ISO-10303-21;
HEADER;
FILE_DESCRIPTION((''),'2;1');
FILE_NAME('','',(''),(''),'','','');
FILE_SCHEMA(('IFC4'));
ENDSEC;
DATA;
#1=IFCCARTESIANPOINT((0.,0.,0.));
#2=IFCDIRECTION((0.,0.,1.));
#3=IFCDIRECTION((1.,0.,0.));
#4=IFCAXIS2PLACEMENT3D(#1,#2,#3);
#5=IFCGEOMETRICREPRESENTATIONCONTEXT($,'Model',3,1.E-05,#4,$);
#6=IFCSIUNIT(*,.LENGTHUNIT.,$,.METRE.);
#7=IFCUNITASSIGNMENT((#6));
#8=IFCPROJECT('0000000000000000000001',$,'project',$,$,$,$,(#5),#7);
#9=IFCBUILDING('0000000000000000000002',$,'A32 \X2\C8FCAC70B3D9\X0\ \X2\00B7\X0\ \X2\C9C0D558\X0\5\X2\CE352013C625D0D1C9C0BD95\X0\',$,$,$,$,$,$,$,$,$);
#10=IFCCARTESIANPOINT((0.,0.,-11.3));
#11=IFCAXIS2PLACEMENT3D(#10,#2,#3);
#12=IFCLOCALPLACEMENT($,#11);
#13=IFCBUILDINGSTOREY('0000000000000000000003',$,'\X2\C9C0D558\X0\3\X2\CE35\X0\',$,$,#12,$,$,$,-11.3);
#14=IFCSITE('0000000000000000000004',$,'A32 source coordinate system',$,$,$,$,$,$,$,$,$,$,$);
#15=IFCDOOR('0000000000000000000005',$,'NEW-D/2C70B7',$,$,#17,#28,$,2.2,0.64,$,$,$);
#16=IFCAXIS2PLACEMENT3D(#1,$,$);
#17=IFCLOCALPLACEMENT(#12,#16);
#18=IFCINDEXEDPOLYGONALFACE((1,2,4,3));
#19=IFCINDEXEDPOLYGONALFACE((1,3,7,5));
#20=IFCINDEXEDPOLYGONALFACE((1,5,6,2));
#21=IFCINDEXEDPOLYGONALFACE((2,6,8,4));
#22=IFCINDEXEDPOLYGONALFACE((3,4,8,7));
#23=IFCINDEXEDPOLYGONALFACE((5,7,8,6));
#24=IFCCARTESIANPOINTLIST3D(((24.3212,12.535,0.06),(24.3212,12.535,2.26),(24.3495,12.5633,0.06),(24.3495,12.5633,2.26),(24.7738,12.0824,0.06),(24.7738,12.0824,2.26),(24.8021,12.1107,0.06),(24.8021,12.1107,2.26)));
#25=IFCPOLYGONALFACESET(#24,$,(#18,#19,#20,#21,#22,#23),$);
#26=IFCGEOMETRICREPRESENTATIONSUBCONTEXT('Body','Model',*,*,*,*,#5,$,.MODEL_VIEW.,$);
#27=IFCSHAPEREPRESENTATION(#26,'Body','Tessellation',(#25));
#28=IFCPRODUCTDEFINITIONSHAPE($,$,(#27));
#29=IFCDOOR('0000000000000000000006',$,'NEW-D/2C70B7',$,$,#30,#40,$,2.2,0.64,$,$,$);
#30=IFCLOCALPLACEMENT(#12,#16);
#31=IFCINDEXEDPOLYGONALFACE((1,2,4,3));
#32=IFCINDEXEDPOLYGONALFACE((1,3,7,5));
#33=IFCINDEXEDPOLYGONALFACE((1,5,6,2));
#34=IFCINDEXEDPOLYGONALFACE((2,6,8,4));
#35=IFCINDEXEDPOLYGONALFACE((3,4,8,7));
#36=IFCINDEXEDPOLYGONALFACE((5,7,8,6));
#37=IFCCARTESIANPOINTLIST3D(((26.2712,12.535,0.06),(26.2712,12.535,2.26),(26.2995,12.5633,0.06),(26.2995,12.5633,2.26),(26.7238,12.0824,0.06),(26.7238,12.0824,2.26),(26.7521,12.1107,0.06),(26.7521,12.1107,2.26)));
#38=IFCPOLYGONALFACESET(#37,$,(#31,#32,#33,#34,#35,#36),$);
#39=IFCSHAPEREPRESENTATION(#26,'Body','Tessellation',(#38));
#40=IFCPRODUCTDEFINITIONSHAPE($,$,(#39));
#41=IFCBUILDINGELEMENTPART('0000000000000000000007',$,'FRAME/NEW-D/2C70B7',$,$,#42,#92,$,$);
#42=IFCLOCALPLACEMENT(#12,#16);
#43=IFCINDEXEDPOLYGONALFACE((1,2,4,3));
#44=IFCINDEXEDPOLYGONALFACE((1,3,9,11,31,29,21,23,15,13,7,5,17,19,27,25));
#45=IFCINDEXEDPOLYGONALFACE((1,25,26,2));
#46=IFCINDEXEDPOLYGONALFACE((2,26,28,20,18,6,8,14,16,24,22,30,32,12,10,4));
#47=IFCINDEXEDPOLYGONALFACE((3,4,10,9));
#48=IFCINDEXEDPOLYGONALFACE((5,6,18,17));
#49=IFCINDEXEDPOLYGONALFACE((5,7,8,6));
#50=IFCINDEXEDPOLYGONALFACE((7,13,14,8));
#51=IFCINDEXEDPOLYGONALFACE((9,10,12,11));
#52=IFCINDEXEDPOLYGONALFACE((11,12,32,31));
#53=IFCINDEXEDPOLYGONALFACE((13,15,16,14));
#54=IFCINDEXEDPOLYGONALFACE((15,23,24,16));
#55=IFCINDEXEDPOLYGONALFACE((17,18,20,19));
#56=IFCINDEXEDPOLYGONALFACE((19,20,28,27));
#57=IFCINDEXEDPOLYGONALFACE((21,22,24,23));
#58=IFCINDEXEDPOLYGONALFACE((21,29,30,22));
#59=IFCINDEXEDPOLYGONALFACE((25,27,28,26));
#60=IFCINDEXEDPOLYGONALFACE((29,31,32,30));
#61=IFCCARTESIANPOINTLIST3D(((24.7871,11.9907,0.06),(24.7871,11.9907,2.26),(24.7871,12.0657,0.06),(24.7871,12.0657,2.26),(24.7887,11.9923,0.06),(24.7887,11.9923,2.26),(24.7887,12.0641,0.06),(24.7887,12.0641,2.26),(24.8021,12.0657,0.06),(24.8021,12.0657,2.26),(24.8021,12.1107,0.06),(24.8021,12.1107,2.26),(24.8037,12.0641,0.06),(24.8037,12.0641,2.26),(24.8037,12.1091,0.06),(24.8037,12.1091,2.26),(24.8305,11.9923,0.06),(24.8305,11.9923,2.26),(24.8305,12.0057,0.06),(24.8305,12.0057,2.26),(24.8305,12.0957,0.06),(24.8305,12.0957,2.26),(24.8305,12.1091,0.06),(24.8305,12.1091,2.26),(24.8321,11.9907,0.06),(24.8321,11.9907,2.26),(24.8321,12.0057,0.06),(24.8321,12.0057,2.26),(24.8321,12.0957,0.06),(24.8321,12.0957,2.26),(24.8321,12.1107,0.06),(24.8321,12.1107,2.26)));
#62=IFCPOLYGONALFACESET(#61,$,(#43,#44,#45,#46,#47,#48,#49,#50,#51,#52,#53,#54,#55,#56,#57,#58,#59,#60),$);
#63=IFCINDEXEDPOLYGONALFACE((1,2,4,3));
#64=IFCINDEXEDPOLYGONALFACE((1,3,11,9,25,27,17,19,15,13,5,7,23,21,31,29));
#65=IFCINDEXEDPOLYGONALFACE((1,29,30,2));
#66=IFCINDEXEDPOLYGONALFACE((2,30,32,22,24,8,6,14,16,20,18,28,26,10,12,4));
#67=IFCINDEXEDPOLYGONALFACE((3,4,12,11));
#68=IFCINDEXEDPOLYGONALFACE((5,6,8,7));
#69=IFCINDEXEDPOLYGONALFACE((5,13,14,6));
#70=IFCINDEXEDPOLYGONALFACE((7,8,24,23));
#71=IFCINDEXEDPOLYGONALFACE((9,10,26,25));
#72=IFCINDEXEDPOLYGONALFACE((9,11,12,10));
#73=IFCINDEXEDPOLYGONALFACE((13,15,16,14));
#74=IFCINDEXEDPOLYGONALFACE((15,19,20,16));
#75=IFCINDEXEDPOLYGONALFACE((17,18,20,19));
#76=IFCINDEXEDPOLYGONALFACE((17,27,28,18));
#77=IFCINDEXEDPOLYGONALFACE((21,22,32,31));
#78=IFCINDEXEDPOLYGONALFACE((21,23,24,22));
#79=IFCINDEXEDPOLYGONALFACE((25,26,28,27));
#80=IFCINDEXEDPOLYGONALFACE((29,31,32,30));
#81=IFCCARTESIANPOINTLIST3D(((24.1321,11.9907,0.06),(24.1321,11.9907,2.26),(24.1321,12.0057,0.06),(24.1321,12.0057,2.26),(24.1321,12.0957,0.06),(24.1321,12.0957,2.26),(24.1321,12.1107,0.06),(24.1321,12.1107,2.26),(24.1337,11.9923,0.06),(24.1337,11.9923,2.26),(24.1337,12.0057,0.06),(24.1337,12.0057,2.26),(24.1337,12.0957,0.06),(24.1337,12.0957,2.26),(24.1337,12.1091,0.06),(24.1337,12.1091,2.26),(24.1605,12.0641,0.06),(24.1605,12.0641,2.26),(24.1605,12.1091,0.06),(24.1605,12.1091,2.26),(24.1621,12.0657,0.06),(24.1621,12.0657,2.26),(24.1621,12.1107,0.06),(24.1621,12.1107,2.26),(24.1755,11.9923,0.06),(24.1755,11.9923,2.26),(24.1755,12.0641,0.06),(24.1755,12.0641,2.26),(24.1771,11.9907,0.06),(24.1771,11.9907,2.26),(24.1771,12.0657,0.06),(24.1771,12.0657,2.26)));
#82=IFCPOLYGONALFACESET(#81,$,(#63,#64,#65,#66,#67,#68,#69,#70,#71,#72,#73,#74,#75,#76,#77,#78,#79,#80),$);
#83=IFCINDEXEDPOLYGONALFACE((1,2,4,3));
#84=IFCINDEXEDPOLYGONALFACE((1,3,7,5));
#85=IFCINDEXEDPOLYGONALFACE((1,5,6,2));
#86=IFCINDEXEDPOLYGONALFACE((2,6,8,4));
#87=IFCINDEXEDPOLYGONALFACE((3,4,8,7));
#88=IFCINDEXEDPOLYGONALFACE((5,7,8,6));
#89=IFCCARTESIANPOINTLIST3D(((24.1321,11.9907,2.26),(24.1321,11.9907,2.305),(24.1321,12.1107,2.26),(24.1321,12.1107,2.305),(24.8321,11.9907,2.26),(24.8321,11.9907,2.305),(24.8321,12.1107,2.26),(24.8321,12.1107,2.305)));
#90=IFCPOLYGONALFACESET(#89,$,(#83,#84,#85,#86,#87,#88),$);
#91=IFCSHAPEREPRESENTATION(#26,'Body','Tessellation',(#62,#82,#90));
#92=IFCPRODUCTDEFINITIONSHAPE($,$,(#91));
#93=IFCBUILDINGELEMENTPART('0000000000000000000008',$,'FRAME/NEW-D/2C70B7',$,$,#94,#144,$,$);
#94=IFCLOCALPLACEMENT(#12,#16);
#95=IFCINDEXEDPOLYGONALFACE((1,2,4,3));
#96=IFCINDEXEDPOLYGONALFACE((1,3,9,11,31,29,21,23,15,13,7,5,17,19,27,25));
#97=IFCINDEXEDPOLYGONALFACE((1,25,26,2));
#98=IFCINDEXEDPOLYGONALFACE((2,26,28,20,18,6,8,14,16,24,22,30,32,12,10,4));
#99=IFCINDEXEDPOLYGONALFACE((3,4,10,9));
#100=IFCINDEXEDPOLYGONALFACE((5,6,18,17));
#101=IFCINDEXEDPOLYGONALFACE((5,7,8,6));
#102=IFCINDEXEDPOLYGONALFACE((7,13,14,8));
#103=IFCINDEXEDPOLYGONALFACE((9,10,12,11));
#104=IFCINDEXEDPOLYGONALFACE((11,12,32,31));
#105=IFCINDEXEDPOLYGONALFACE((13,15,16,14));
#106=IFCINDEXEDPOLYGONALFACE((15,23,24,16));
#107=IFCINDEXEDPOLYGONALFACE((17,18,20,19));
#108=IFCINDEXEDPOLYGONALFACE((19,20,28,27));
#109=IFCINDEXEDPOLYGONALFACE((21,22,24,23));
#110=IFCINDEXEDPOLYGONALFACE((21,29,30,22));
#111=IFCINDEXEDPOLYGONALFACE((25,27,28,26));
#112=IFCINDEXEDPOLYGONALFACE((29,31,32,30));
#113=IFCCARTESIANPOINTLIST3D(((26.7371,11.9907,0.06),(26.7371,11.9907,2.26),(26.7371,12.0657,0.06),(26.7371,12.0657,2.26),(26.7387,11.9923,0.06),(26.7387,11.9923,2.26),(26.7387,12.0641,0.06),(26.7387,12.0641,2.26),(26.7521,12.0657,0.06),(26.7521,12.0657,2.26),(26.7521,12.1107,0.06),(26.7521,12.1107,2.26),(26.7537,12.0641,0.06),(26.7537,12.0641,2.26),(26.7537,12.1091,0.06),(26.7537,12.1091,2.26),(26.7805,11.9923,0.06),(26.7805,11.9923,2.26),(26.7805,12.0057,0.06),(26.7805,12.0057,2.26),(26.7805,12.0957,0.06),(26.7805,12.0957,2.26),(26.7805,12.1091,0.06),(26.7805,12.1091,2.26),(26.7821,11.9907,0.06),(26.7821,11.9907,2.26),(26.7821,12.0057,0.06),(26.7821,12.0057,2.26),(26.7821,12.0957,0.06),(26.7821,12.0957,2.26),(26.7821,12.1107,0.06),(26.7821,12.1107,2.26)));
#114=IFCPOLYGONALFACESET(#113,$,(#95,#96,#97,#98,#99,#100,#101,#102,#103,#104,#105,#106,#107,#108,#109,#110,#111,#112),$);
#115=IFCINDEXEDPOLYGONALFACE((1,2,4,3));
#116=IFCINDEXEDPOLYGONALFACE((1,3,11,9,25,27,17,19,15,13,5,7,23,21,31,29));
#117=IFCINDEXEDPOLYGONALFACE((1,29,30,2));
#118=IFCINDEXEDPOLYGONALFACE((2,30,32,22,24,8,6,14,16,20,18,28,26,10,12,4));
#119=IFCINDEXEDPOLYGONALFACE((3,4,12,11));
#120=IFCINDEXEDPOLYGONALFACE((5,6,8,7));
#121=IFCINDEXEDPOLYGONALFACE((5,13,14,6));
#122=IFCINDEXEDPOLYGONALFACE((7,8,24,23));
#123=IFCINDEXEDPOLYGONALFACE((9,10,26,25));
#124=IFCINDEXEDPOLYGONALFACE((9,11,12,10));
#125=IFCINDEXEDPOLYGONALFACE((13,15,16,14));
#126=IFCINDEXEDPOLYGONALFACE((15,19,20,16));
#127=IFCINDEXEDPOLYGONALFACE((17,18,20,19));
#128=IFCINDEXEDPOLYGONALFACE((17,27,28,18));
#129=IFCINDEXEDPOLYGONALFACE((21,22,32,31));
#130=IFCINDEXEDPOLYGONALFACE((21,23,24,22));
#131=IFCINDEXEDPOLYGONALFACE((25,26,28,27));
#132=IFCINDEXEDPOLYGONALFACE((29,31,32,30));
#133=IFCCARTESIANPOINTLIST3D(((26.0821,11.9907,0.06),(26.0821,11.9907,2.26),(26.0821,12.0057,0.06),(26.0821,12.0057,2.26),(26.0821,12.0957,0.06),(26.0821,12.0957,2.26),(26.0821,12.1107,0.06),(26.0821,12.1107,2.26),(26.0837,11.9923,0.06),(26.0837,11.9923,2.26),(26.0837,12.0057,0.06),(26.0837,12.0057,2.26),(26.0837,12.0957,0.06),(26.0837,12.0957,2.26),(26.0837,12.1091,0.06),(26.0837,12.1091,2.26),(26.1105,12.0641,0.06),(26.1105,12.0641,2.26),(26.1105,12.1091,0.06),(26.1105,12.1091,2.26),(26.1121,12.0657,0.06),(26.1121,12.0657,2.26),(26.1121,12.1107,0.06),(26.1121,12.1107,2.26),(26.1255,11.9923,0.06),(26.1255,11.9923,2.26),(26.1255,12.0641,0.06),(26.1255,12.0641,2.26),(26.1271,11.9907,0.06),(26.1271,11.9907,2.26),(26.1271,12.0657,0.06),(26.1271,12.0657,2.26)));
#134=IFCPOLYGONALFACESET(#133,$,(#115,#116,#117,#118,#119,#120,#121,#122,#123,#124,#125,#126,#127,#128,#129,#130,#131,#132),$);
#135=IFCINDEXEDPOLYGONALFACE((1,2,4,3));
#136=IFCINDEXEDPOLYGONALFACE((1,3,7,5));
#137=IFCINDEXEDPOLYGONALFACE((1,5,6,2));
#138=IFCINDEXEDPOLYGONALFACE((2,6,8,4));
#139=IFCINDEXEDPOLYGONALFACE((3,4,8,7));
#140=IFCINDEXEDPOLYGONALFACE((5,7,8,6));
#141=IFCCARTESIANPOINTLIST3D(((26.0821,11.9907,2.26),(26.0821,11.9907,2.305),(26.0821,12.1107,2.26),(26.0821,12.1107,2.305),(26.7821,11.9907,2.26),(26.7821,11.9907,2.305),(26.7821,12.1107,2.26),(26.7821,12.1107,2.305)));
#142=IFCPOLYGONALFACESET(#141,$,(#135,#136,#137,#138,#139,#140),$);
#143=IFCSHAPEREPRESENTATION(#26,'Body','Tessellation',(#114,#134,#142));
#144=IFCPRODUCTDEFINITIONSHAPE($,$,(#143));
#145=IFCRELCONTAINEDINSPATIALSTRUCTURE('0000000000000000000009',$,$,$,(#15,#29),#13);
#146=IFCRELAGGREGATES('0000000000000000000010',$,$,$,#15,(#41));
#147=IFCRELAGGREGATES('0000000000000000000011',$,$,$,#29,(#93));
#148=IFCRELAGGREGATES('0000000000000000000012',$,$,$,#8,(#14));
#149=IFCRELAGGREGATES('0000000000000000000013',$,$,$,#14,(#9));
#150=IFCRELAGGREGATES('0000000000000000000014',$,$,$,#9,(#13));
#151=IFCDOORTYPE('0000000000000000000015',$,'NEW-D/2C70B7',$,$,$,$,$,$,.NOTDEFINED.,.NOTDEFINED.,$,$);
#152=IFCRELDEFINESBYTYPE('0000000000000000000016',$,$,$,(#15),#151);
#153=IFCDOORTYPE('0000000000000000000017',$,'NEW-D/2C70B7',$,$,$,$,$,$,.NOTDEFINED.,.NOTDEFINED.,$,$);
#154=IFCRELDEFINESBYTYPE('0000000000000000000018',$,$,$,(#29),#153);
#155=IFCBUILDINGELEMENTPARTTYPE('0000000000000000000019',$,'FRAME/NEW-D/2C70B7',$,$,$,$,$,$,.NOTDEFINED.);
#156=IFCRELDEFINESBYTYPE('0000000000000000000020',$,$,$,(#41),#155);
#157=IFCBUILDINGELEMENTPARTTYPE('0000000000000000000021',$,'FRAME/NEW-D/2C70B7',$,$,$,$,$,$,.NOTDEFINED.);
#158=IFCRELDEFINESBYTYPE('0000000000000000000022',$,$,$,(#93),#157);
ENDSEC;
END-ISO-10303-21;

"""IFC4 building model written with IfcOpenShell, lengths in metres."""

from ifc_helpers import new_model, si_unit, frame, origin, origin_with_axes, place, context, subcontext, project, spatial, polyline, outline, extrude, source, transform, mapped, type_object, type_shapes, element, aggregate, save


model = new_model("IFC4")

# Units and contexts
model_context = context("Model", 3, precision=1e-05, world=origin_with_axes())
body_context = subcontext(model_context, "Body", "Model", "MODEL_VIEW")
ifc_project = project(units=[si_unit("LENGTHUNIT", "METRE")], contexts=[model_context])

# Site, building, storey
site = spatial("IfcSite", under=ifc_project, Name="A32 source coordinate system")
building = spatial("IfcBuilding", under=site, Name="A32 주거동 · 지하5층–옥탑지붕")
storey_placement = place(None, frame((0.0, 0.0, -11.3), z_axis=(0.0, 0.0, 1.0), x_axis=(1.0, 0.0, 0.0)))
storey = spatial("IfcBuildingStorey", under=building, at=storey_placement, Name="지하3층", Elevation=-11.3)

# Doors
door_type_1 = type_object("IfcDoorType", Name="NEW-D/2C70B7", OperationType="NOTDEFINED", PredefinedType="NOTDEFINED")
shared_shape_1 = source(origin(), body_context, "Body", "SweptSolid", [
    extrude(outline(polyline([(24.8021, 12.1107), (24.7738, 12.0824), (24.3212, 12.535), (24.3495, 12.5633), (24.8021, 12.1107)])), frame((0.0, 0.0, 0.06)), (0.0, 0.0, 1.0), 2.2),
])
type_shapes(door_type_1, [shared_shape_1])
door_1_placement = place(storey_placement, origin_with_axes())
door_1 = element("IfcDoor", 1, at=door_1_placement, inside=storey, type_object=door_type_1, Name="NEW-D/2C70B7", OverallHeight=2.2, OverallWidth=0.64, context=body_context, shape_type="MappedRepresentation", body=[
    mapped(shared_shape_1, transform((0.0, 0.0, 0.0), scale=1.0)),
])
door_type_2 = type_object("IfcDoorType", Name="NEW-D/2C70B7", OperationType="NOTDEFINED", PredefinedType="NOTDEFINED")
shared_shape_2 = source(origin(), body_context, "Body", "SweptSolid", [
    extrude(outline(polyline([(26.7521, 12.1107), (26.7238, 12.0824), (26.2712, 12.535), (26.2995, 12.5633), (26.7521, 12.1107)])), frame((0.0, 0.0, 0.06)), (0.0, 0.0, 1.0), 2.2),
])
type_shapes(door_type_2, [shared_shape_2])
door_2_placement = place(storey_placement, origin_with_axes())
door_2 = element("IfcDoor", 2, at=door_2_placement, inside=storey, type_object=door_type_2, Name="NEW-D/2C70B7", OverallHeight=2.2, OverallWidth=0.64, context=body_context, shape_type="MappedRepresentation", body=[
    mapped(shared_shape_2, transform((0.0, 0.0, 0.0), scale=1.0)),
])

# Building element parts
building_element_part_type_1 = type_object("IfcBuildingElementPartType", Name="FRAME/NEW-D/2C70B7", PredefinedType="NOTDEFINED")
shared_shape_3 = source(origin(), body_context, "Body", "SweptSolid", [
    extrude(outline(polyline([(24.8037, 12.1091), (24.8037, 12.0641), (24.7887, 12.0641), (24.7887, 11.9923), (24.8305, 11.9923), (24.8305, 12.0057), (24.8321, 12.0057), (24.8321, 11.9907), (24.7871, 11.9907), (24.7871, 12.0657), (24.8021, 12.0657), (24.8021, 12.1107), (24.8321, 12.1107), (24.8321, 12.0957), (24.8305, 12.0957), (24.8305, 12.1091), (24.8037, 12.1091)])), frame((0.0, 0.0, 0.06)), (0.0, 0.0, 1.0), 2.2),
    extrude(outline(polyline([(24.1321, 12.1107), (24.1621, 12.1107), (24.1621, 12.0657), (24.1771, 12.0657), (24.1771, 11.9907), (24.1321, 11.9907), (24.1321, 12.0057), (24.1337, 12.0057), (24.1337, 11.9923), (24.1755, 11.9923), (24.1755, 12.0641), (24.1605, 12.0641), (24.1605, 12.1091), (24.1337, 12.1091), (24.1337, 12.0957), (24.1321, 12.0957), (24.1321, 12.1107)])), frame((0.0, 0.0, 0.06)), (0.0, 0.0, 1.0), 2.2),
    extrude(outline(polyline([(24.8321, 11.9907), (24.8321, 12.1107), (24.1321, 12.1107), (24.1321, 11.9907), (24.8321, 11.9907)])), frame((0.0, 0.0, 2.26)), (0.0, 0.0, 1.0), 0.045),
])
type_shapes(building_element_part_type_1, [shared_shape_3])
building_element_part_1_placement = place(door_1_placement, origin_with_axes())
building_element_part_1 = element("IfcBuildingElementPart", 3, at=building_element_part_1_placement, type_object=building_element_part_type_1, Name="FRAME/NEW-D/2C70B7", context=body_context, shape_type="MappedRepresentation", body=[
    mapped(shared_shape_3, transform((0.0, 0.0, 0.0), scale=1.0)),
])
aggregate(door_1, [building_element_part_1])
building_element_part_type_2 = type_object("IfcBuildingElementPartType", Name="FRAME/NEW-D/2C70B7", PredefinedType="NOTDEFINED")
shared_shape_4 = source(origin(), body_context, "Body", "SweptSolid", [
    extrude(outline(polyline([(26.7537, 12.1091), (26.7537, 12.0641), (26.7387, 12.0641), (26.7387, 11.9923), (26.7805, 11.9923), (26.7805, 12.0057), (26.7821, 12.0057), (26.7821, 11.9907), (26.7371, 11.9907), (26.7371, 12.0657), (26.7521, 12.0657), (26.7521, 12.1107), (26.7821, 12.1107), (26.7821, 12.0957), (26.7805, 12.0957), (26.7805, 12.1091), (26.7537, 12.1091)])), frame((0.0, 0.0, 0.06)), (0.0, 0.0, 1.0), 2.2),
    extrude(outline(polyline([(26.0821, 12.1107), (26.1121, 12.1107), (26.1121, 12.0657), (26.1271, 12.0657), (26.1271, 11.9907), (26.0821, 11.9907), (26.0821, 12.0057), (26.0837, 12.0057), (26.0837, 11.9923), (26.1255, 11.9923), (26.1255, 12.0641), (26.1105, 12.0641), (26.1105, 12.1091), (26.0837, 12.1091), (26.0837, 12.0957), (26.0821, 12.0957), (26.0821, 12.1107)])), frame((0.0, 0.0, 0.06)), (0.0, 0.0, 1.0), 2.2),
    extrude(outline(polyline([(26.7821, 11.9907), (26.7821, 12.1107), (26.0821, 12.1107), (26.0821, 11.9907), (26.7821, 11.9907)])), frame((0.0, 0.0, 2.26)), (0.0, 0.0, 1.0), 0.045),
])
type_shapes(building_element_part_type_2, [shared_shape_4])
building_element_part_2_placement = place(door_2_placement, origin_with_axes())
building_element_part_2 = element("IfcBuildingElementPart", 4, at=building_element_part_2_placement, type_object=building_element_part_type_2, Name="FRAME/NEW-D/2C70B7", context=body_context, shape_type="MappedRepresentation", body=[
    mapped(shared_shape_4, transform((0.0, 0.0, 0.0), scale=1.0)),
])
aggregate(door_2, [building_element_part_2])

save(model, "model.ifc")
